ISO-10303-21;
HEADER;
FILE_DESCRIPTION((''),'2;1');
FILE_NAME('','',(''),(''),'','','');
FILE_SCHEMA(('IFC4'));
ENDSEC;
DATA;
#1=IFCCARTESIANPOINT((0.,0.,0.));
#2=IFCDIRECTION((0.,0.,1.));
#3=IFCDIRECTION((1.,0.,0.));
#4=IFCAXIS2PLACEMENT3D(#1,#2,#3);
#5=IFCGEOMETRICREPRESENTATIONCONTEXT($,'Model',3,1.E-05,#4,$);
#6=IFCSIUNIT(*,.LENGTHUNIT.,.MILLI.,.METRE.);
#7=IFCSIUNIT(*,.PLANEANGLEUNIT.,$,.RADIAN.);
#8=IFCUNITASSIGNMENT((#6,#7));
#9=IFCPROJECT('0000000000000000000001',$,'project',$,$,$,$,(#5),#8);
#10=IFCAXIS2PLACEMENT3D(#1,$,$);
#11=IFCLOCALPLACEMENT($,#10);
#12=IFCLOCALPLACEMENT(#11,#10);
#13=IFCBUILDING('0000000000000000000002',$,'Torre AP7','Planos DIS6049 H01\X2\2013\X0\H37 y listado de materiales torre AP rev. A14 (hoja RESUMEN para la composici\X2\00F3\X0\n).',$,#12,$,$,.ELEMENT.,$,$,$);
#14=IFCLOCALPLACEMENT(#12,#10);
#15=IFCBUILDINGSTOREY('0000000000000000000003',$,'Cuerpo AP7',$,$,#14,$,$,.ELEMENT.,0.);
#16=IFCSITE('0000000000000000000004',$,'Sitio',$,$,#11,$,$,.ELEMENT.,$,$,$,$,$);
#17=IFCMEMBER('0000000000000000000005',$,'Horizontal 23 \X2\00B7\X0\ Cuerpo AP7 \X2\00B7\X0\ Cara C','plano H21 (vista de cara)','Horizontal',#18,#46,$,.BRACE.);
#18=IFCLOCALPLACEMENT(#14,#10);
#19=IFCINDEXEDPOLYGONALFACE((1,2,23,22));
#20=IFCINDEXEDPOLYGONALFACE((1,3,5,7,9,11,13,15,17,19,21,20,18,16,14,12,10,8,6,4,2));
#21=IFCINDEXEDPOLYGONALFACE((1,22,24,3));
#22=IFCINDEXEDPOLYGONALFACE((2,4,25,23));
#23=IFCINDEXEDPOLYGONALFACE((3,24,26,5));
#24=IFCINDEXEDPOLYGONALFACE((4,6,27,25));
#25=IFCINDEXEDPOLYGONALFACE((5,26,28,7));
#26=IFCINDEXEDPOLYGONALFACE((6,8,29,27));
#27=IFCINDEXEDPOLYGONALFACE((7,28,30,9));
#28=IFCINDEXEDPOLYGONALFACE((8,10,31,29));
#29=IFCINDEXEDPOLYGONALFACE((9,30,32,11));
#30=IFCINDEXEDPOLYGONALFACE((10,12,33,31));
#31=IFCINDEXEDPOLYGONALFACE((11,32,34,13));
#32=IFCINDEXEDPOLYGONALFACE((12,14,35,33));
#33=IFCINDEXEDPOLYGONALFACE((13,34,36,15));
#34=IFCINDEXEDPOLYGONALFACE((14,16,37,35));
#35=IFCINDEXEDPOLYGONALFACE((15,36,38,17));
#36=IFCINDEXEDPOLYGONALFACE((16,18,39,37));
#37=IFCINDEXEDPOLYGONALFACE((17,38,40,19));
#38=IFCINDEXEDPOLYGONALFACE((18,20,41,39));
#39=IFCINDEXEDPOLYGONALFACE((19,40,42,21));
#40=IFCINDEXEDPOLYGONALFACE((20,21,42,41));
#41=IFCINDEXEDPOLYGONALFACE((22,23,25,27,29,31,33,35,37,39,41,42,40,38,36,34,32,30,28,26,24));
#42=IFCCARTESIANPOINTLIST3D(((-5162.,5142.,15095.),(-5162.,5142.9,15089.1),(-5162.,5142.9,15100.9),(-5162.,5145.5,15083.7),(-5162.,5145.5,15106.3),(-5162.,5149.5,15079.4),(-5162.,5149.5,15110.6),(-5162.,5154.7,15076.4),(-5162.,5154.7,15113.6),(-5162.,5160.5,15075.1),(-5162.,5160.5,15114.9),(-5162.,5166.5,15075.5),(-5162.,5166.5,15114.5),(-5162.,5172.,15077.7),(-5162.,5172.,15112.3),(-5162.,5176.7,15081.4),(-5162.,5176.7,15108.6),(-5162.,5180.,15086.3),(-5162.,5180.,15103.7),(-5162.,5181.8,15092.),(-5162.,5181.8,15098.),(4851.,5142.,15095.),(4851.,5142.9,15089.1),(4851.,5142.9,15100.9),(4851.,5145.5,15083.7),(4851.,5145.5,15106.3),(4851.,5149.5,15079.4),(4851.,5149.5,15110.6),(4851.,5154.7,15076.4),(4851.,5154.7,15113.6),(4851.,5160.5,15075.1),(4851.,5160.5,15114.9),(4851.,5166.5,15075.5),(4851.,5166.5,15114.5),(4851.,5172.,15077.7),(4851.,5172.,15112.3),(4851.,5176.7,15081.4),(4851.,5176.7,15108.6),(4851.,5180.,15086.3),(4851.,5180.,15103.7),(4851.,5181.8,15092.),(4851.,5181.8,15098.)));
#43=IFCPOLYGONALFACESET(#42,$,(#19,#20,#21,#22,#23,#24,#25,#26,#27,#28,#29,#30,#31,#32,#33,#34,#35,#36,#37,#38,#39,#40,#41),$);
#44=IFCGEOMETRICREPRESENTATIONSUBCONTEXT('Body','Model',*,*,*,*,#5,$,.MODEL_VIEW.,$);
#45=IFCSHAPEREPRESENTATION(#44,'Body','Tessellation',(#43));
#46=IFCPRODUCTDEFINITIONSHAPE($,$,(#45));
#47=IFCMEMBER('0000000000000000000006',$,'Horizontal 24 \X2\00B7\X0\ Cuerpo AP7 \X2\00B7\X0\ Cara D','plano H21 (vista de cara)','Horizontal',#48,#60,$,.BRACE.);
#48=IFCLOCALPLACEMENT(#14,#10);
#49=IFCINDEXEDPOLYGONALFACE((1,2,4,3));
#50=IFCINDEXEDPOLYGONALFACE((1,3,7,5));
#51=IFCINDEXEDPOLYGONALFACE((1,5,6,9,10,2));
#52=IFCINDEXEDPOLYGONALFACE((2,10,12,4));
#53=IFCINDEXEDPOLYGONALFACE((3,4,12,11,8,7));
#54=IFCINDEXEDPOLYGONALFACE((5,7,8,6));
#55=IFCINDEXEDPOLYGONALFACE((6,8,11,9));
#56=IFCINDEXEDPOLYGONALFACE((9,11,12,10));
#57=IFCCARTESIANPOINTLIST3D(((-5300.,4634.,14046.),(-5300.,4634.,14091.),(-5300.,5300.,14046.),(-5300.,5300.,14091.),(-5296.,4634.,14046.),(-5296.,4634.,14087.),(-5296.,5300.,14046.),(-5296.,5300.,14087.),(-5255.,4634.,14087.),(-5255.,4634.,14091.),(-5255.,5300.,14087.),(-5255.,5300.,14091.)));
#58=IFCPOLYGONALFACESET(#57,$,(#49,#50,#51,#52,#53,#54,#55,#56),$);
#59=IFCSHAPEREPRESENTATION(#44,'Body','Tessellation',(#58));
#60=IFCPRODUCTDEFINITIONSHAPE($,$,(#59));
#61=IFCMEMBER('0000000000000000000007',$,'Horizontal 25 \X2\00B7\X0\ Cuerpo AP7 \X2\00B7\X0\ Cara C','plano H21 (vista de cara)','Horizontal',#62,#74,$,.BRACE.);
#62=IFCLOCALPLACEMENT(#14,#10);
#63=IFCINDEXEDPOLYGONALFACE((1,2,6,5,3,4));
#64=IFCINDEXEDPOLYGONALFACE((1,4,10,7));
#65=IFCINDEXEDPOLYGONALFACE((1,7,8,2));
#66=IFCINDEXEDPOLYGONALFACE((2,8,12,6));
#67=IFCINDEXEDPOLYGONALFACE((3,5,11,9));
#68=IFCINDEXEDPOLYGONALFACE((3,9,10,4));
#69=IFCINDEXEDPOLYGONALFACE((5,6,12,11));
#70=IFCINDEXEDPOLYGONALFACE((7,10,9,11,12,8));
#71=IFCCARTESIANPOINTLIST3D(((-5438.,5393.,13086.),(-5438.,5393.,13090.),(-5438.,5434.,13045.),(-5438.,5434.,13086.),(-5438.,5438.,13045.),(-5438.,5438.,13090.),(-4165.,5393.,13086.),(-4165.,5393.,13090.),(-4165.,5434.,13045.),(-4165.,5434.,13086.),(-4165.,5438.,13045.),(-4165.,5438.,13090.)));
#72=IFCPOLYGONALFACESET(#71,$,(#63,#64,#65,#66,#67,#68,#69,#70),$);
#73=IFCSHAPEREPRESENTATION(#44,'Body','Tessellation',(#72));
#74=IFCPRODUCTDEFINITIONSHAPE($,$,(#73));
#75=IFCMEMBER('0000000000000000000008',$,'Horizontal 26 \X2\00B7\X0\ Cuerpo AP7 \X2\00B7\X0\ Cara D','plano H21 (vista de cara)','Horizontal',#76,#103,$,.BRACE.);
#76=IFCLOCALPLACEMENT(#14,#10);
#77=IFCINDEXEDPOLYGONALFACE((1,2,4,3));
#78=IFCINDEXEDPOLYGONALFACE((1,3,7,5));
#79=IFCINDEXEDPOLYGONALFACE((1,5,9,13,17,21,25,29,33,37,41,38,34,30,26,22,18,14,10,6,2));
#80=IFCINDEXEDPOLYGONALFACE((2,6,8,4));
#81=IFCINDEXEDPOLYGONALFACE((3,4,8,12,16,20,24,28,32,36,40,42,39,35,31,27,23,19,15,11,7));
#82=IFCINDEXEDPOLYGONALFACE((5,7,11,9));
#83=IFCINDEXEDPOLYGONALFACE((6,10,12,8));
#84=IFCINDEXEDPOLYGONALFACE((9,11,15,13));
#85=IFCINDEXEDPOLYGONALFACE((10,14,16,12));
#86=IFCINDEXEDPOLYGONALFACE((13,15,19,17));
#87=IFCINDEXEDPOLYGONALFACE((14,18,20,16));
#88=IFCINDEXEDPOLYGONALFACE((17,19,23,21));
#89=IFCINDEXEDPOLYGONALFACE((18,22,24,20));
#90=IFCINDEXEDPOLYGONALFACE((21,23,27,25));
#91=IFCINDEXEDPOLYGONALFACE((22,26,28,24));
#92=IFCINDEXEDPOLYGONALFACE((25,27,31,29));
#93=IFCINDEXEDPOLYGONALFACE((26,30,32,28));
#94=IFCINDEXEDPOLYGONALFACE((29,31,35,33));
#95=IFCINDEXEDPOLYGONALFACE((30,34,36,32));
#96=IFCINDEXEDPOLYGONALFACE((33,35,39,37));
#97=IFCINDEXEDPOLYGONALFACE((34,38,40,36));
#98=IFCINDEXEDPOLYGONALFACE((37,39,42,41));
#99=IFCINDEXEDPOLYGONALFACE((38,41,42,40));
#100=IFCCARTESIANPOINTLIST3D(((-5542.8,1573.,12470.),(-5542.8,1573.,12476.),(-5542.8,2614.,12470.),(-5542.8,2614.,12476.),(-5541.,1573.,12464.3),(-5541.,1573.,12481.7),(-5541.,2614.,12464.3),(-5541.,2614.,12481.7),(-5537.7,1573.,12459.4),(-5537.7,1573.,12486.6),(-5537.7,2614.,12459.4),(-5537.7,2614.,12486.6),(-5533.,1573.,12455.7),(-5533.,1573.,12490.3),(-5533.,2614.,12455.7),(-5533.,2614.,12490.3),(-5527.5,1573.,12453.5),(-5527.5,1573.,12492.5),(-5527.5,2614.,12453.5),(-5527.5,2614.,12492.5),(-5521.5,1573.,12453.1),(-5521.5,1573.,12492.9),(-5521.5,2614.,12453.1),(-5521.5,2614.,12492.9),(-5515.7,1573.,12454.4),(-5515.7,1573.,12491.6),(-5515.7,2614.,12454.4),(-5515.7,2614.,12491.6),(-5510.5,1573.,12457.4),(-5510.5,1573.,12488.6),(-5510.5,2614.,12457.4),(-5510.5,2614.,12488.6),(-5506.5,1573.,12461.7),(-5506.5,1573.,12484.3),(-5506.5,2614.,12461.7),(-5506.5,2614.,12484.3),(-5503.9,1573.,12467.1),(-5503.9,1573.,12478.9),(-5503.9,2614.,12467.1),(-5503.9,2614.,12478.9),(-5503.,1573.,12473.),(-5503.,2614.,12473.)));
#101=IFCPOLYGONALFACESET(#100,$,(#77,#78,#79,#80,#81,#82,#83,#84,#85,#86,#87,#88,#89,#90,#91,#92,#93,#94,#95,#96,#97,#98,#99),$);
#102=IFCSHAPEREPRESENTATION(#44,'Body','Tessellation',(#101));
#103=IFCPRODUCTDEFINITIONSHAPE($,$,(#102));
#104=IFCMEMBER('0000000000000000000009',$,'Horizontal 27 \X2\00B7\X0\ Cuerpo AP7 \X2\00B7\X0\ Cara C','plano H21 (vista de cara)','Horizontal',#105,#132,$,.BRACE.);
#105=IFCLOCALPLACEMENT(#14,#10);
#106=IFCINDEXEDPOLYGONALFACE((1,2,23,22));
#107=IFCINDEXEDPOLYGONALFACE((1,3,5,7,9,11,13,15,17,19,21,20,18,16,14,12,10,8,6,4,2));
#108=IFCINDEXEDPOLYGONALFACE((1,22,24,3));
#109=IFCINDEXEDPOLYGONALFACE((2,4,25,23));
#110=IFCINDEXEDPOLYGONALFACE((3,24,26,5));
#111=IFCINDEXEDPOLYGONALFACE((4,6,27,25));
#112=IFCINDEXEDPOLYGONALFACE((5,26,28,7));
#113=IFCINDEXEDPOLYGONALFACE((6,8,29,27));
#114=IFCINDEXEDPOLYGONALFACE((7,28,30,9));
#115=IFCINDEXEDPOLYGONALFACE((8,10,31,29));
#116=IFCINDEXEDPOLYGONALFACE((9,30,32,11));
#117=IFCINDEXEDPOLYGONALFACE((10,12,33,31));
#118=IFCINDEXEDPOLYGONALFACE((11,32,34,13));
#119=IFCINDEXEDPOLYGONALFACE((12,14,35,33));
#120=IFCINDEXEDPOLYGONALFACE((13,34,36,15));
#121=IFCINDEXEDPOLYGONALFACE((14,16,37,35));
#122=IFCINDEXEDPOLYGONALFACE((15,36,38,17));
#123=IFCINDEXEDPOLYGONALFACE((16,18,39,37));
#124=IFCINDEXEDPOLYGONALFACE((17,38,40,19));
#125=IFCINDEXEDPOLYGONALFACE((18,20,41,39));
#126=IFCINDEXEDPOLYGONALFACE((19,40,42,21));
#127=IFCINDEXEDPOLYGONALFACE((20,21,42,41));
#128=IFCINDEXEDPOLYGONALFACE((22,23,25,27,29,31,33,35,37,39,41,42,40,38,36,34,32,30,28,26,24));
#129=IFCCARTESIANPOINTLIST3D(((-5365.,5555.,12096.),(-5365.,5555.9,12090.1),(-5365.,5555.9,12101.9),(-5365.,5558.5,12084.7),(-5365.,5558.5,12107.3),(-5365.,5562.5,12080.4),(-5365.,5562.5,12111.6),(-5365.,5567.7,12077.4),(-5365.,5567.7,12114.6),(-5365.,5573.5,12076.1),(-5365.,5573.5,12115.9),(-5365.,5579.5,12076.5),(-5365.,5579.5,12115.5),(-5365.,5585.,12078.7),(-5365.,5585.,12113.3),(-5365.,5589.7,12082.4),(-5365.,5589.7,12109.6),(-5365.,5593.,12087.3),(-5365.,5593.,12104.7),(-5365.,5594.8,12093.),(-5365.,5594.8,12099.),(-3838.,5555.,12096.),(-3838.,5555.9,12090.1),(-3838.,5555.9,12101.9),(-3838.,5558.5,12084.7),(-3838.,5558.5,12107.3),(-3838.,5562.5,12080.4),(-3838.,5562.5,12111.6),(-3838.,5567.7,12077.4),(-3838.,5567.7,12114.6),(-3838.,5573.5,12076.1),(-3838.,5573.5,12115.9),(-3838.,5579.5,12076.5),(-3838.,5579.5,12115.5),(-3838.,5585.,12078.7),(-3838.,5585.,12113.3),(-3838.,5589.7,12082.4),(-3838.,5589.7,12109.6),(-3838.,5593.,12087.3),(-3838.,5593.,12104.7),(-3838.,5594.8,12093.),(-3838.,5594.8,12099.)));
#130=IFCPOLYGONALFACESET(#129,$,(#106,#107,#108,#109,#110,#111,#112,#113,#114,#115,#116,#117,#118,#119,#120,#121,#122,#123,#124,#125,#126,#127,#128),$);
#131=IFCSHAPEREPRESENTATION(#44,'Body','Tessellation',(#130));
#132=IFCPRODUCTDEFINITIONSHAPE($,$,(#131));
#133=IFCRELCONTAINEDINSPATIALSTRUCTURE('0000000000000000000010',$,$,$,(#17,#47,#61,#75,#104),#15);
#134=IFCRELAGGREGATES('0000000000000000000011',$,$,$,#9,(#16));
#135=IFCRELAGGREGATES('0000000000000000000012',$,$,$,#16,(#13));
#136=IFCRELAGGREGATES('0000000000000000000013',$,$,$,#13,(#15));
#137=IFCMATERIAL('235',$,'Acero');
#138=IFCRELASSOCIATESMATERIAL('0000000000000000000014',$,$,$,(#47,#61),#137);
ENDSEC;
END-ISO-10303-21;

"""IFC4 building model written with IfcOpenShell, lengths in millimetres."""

from ifc_helpers import new_model, si_unit, frame, frame_2d, origin, origin_with_axes, place, context, subcontext, project, spatial, circle, l_section, extrude, material, element, save


model = new_model("IFC4")

# Units and contexts
model_context = context("Model", 3, precision=1e-05, world=origin_with_axes())
body_context = subcontext(model_context, "Body", "Model", "MODEL_VIEW")
ifc_project = project(units=[si_unit("LENGTHUNIT", "METRE", prefix="MILLI"), si_unit("PLANEANGLEUNIT", "RADIAN")], contexts=[model_context])

# Site, building, storey
site_placement = place(None, origin())
site = spatial("IfcSite", under=ifc_project, at=site_placement, Name="Sitio", CompositionType="ELEMENT")
building_placement = place(site_placement, origin())
building = spatial("IfcBuilding", under=site, at=building_placement, Name="Torre AP7", Description="Planos DIS6049 H01–H37 y listado de materiales torre AP rev. A14 (hoja RESUMEN para la composición).", CompositionType="ELEMENT")
storey_placement = place(building_placement, origin())
storey = spatial("IfcBuildingStorey", under=building, at=storey_placement, Name="Cuerpo AP7", CompositionType="ELEMENT", Elevation=0.0)

# Members
ifc_material_1 = material(Name="235", Category="Acero")
member_1_placement = place(storey_placement, frame((-5162.0, 5162.0, 15095.0), z_axis=(1.0, 0.0, 0.0), x_axis=(0.0, -1.0, 0.0)))
element("IfcMember", 1, at=member_1_placement, inside=storey, Name="Horizontal 23 · Cuerpo AP7 · Cara C", Description="plano H21 (vista de cara)", ObjectType="Horizontal", PredefinedType="BRACE", context=body_context, shape_type="SweptSolid", body=[
    extrude(circle(Radius=20.0), None, (0.0, 0.0, 1.0), 10013.0),
])
member_2_placement = place(storey_placement, frame((-5300.0, 4634.0, 14091.0), z_axis=(0.0, 1.0, 0.0), x_axis=(1.0, 0.0, 0.0)))
element("IfcMember", 2, at=member_2_placement, inside=storey, material=ifc_material_1, Name="Horizontal 24 · Cuerpo AP7 · Cara D", Description="plano H21 (vista de cara)", ObjectType="Horizontal", PredefinedType="BRACE", context=body_context, shape_type="SweptSolid", body=[
    extrude(l_section(Depth=45.0, Width=45.0, Thickness=4.0, at=frame_2d((22.5, 22.5))), None, (0.0, 0.0, 1.0), 666.0),
])
member_3_placement = place(storey_placement, frame((-5438.0, 5438.0, 13090.0), z_axis=(1.0, 0.0, 0.0), x_axis=(0.0, -1.0, 0.0)))
element("IfcMember", 3, at=member_3_placement, inside=storey, material=ifc_material_1, Name="Horizontal 25 · Cuerpo AP7 · Cara C", Description="plano H21 (vista de cara)", ObjectType="Horizontal", PredefinedType="BRACE", context=body_context, shape_type="SweptSolid", body=[
    extrude(l_section(Depth=45.0, Width=45.0, Thickness=4.0, at=frame_2d((22.5, 22.5))), None, (0.0, 0.0, 1.0), 1273.0),
])
member_4_placement = place(storey_placement, frame((-5523.0, 1573.0, 12473.0), z_axis=(0.0, 1.0, 0.0), x_axis=(1.0, 0.0, 0.0)))
element("IfcMember", 4, at=member_4_placement, inside=storey, Name="Horizontal 26 · Cuerpo AP7 · Cara D", Description="plano H21 (vista de cara)", ObjectType="Horizontal", PredefinedType="BRACE", context=body_context, shape_type="SweptSolid", body=[
    extrude(circle(Radius=20.0), None, (0.0, 0.0, 1.0), 1041.0),
])
member_5_placement = place(storey_placement, frame((-5365.0, 5575.0, 12096.0), z_axis=(1.0, 0.0, 0.0), x_axis=(0.0, -1.0, 0.0)))
element("IfcMember", 5, at=member_5_placement, inside=storey, Name="Horizontal 27 · Cuerpo AP7 · Cara C", Description="plano H21 (vista de cara)", ObjectType="Horizontal", PredefinedType="BRACE", context=body_context, shape_type="SweptSolid", body=[
    extrude(circle(Radius=20.0), None, (0.0, 0.0, 1.0), 1527.0),
])

save(model, "model.ifc")
